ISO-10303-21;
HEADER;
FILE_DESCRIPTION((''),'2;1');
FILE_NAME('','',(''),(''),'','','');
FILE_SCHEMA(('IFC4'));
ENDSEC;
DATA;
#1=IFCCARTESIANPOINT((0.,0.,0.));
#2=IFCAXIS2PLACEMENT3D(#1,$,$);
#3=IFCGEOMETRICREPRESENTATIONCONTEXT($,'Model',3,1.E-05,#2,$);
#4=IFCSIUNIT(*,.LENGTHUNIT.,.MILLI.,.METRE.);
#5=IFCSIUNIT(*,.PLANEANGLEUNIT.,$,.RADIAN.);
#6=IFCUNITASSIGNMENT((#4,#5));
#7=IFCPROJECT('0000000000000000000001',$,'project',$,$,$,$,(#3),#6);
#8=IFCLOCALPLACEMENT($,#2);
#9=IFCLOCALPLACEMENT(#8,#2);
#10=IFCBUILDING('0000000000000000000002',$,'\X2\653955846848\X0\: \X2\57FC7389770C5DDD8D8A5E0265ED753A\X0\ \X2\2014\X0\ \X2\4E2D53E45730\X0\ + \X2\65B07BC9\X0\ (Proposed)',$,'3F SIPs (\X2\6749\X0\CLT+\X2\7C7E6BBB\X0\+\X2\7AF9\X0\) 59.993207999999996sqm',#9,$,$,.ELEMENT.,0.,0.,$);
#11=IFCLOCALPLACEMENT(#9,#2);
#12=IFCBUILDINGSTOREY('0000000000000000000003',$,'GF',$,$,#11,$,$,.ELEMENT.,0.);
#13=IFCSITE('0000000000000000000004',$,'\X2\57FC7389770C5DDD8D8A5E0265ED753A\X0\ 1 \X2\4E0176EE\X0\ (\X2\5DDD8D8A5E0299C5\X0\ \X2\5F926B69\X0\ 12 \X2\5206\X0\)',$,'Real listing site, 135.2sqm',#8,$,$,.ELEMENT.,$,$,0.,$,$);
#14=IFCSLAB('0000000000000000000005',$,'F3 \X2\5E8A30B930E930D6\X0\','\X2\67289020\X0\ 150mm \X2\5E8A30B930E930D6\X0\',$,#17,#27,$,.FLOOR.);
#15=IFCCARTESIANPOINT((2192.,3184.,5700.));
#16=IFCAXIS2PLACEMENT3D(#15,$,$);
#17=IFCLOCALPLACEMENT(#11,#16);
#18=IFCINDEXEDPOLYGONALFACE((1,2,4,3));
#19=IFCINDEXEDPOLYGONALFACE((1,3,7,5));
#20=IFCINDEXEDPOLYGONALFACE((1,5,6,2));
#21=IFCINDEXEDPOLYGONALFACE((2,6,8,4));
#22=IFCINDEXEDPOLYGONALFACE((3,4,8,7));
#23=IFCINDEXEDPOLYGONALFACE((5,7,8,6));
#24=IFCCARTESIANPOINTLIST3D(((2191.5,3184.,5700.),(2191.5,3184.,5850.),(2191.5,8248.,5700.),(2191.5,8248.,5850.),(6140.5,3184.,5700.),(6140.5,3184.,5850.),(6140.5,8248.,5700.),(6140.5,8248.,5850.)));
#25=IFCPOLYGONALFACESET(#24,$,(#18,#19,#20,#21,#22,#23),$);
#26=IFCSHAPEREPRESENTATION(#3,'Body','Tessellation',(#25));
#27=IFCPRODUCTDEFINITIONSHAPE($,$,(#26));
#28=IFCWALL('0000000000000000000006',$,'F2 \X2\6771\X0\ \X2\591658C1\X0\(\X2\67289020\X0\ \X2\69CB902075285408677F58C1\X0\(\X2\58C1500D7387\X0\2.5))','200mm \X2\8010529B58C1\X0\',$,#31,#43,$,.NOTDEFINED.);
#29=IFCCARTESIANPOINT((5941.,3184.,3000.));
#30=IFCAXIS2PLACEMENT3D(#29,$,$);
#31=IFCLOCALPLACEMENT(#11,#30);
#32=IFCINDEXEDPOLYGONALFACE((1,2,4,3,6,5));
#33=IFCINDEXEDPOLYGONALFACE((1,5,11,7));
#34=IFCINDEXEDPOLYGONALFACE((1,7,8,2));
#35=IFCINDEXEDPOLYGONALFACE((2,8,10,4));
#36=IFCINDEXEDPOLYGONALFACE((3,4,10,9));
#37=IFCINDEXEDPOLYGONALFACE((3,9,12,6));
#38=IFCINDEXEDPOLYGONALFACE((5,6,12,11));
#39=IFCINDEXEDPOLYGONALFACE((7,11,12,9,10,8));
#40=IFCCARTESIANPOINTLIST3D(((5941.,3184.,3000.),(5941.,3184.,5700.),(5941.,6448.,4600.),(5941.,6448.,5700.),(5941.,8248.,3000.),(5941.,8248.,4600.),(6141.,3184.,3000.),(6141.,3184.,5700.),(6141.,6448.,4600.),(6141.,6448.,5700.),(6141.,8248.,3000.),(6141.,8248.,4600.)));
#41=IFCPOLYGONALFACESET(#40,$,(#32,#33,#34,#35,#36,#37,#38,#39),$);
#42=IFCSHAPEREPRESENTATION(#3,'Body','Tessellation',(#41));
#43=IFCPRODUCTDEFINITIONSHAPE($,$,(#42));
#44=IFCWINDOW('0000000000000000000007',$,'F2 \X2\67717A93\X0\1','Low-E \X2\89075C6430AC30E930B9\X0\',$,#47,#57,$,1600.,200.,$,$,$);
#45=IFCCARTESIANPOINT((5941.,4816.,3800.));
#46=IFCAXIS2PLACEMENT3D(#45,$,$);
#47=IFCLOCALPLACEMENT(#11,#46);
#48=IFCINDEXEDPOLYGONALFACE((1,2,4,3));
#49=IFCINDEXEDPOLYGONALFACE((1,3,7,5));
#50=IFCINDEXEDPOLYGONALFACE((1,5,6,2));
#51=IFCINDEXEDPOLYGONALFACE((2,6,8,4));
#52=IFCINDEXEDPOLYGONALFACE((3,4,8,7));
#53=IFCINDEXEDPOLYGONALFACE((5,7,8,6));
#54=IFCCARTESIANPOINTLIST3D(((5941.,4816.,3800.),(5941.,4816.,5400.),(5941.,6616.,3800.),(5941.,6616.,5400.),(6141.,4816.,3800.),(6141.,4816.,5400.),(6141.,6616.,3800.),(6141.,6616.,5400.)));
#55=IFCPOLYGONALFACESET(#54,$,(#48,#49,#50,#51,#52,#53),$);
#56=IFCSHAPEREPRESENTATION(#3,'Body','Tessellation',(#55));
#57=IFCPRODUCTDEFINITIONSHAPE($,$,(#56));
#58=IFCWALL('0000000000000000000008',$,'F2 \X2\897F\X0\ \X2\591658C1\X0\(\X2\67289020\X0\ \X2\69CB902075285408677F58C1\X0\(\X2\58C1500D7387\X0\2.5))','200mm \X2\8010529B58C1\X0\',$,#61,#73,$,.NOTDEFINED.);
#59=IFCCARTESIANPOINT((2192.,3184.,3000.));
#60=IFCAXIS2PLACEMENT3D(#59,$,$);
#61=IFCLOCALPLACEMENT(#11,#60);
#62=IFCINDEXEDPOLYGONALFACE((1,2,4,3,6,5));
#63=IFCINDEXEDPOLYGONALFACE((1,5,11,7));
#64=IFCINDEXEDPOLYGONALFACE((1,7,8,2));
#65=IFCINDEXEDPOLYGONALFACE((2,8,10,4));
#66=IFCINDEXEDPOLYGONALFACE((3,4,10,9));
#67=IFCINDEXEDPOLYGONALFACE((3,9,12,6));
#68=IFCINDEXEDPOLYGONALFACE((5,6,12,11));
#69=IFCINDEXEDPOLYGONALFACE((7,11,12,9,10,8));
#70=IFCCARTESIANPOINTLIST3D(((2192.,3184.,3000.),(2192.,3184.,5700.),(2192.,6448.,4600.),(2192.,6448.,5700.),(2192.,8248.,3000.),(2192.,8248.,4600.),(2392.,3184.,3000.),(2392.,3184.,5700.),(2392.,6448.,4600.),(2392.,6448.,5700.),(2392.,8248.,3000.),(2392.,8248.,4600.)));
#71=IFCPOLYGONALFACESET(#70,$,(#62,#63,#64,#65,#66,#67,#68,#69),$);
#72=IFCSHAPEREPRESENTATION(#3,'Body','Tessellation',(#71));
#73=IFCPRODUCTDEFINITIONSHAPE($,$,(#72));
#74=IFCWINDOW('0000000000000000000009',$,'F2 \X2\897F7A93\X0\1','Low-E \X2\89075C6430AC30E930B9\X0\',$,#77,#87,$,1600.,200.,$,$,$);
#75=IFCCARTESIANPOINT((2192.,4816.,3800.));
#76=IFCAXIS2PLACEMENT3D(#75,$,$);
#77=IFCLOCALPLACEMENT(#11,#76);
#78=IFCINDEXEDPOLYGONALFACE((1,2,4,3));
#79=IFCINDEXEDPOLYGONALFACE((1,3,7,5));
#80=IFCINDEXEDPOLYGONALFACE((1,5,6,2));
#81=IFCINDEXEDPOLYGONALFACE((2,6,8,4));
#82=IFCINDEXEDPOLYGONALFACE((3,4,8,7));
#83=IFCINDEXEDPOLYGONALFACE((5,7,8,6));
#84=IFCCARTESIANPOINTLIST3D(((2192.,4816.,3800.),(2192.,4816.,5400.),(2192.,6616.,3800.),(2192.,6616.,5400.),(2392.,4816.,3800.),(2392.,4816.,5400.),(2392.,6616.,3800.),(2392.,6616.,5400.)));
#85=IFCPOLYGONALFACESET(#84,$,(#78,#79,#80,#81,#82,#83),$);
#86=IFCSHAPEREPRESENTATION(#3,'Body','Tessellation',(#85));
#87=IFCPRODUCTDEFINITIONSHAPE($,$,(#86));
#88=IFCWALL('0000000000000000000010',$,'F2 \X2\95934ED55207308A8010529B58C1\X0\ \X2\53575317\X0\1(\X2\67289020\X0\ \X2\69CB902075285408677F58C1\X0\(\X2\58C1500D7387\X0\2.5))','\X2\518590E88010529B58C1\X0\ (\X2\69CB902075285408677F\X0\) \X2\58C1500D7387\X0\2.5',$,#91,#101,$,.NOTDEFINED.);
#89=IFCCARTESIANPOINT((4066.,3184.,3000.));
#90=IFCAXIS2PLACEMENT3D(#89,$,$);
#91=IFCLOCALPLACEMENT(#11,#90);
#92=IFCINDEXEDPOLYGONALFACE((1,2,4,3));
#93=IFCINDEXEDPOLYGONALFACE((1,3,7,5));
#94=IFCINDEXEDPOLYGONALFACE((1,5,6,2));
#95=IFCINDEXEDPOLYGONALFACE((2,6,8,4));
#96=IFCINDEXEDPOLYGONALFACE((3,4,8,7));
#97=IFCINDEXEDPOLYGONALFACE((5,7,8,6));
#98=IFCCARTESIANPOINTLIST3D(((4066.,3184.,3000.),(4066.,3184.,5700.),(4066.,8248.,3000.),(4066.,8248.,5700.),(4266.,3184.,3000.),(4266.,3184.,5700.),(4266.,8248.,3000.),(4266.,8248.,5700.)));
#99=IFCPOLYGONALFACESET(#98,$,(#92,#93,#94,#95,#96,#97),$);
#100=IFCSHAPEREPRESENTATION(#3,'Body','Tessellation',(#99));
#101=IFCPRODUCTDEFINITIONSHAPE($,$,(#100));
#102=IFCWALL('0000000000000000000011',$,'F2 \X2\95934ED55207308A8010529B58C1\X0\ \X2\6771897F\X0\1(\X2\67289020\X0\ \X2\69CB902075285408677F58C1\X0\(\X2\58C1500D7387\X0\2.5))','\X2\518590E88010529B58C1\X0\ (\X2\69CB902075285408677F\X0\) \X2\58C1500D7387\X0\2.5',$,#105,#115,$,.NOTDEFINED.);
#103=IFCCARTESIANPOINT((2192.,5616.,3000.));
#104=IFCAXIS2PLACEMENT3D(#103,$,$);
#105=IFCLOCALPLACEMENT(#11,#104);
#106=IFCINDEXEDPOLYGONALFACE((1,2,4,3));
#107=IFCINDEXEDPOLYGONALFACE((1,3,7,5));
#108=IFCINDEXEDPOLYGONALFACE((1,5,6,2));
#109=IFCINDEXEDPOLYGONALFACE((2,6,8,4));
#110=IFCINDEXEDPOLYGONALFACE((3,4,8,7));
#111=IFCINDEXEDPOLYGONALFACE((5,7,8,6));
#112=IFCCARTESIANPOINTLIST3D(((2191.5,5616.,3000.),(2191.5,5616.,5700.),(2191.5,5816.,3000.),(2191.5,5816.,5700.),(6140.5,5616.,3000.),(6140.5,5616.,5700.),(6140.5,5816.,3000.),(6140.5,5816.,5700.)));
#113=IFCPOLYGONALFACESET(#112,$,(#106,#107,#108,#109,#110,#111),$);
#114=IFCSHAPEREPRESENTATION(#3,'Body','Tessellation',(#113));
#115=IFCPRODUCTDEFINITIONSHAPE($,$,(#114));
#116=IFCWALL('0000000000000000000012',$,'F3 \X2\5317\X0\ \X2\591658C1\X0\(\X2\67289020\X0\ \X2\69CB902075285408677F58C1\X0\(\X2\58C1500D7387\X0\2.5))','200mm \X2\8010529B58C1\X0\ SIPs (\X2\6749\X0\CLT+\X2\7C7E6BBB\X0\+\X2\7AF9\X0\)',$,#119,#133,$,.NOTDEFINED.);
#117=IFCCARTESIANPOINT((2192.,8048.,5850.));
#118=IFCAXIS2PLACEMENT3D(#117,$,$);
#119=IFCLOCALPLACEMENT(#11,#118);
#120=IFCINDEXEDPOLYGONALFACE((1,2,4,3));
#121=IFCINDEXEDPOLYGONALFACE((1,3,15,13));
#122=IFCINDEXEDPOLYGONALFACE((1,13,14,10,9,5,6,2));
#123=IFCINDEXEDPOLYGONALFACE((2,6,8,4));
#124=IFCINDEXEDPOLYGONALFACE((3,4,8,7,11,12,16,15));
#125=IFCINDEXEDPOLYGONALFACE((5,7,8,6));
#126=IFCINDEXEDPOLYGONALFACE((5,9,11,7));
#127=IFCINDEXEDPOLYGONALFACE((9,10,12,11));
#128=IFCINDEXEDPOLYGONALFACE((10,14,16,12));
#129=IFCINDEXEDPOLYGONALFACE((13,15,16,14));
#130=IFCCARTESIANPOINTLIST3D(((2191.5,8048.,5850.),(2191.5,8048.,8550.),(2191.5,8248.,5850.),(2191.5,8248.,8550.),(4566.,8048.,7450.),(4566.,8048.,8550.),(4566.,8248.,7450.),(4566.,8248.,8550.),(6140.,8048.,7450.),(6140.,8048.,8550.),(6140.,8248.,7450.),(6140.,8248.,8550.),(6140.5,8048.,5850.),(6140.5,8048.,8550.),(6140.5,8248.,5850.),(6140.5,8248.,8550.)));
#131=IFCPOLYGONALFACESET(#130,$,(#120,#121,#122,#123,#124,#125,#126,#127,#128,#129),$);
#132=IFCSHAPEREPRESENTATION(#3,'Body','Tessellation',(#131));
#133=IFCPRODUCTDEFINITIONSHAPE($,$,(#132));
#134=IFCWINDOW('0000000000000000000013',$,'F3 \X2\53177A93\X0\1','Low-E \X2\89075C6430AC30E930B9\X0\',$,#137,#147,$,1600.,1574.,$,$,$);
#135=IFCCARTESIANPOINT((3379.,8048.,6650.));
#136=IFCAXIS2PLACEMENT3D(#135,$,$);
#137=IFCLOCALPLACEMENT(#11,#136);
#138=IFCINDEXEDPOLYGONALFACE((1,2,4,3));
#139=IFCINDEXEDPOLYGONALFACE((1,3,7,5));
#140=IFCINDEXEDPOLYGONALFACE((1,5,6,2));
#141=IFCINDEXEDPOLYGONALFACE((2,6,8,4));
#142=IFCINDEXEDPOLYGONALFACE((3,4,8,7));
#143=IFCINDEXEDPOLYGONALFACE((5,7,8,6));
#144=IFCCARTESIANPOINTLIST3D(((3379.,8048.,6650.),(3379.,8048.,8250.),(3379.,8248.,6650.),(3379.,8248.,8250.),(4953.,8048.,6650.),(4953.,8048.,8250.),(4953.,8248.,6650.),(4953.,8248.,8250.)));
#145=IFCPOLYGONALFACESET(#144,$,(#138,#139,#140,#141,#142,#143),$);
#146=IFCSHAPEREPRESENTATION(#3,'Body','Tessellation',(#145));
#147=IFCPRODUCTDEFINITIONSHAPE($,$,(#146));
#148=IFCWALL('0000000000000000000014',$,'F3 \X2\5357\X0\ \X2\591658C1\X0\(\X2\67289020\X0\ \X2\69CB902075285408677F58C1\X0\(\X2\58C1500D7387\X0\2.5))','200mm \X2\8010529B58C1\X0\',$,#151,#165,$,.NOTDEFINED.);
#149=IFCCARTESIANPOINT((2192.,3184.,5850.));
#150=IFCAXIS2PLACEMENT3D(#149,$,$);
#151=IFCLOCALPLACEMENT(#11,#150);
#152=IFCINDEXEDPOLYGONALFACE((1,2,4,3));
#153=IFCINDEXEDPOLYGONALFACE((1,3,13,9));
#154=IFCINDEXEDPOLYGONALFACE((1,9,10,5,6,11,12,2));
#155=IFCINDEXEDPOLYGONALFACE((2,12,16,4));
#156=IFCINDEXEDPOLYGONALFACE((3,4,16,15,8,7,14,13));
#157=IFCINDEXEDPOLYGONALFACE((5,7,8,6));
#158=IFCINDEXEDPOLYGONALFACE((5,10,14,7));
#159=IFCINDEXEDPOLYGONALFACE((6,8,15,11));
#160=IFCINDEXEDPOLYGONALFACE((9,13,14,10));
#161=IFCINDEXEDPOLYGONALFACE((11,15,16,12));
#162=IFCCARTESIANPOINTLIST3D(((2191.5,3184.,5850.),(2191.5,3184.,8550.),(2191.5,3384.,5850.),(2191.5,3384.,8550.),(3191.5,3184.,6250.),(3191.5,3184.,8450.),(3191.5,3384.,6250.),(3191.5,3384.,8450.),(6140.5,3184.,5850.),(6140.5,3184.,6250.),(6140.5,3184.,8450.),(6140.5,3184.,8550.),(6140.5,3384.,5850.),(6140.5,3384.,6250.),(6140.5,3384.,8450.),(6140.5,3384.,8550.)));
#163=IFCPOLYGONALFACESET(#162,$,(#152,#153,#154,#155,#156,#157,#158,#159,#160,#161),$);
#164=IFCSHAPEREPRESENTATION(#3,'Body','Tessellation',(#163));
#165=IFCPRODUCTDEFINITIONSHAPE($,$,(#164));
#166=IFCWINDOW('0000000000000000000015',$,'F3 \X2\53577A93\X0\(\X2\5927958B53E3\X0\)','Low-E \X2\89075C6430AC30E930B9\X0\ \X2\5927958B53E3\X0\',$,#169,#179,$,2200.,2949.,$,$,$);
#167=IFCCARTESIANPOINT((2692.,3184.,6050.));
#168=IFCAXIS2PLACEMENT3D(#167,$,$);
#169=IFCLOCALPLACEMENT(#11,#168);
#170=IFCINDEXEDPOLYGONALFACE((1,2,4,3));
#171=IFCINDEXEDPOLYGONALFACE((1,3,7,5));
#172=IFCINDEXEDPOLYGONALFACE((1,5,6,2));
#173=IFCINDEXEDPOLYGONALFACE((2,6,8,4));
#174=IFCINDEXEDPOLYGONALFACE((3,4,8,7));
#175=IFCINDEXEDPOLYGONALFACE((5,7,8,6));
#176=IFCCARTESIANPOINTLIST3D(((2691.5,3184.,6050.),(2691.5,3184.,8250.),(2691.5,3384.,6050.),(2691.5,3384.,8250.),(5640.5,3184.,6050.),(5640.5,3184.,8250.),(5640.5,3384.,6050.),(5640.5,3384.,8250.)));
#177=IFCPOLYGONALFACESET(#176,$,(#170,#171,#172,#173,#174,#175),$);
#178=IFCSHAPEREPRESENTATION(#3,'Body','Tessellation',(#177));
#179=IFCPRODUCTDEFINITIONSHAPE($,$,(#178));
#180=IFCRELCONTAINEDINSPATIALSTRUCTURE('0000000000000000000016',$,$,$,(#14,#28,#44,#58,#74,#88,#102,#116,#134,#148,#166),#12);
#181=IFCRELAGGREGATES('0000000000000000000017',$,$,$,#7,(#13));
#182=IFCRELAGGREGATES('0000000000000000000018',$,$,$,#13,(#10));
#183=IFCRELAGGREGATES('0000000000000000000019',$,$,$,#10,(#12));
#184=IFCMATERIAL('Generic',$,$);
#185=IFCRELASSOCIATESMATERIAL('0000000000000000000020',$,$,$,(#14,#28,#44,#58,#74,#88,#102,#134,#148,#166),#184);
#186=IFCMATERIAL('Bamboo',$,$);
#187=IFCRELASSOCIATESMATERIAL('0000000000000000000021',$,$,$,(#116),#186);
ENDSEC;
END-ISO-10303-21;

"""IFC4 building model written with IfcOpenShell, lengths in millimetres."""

from ifc_helpers import new_model, si_unit, frame, frame_2d, origin, place, context, project, spatial, rectangle, extrude, material, element, fill, save


model = new_model("IFC4")

# Units and contexts
model_context = context("Model", 3, precision=1e-05, world=origin())
ifc_project = project(units=[si_unit("LENGTHUNIT", "METRE", prefix="MILLI"), si_unit("PLANEANGLEUNIT", "RADIAN")], contexts=[model_context])

# Site, building, storey
site_placement = place(None, origin())
site = spatial("IfcSite", under=ifc_project, at=site_placement, Name="埼玉県川越市旭町 1 丁目 (川越市駅 徒歩 12 分)", ObjectType="Real listing site, 135.2sqm", CompositionType="ELEMENT", RefElevation=0.0)
building_placement = place(site_placement, origin())
building = spatial("IfcBuilding", under=site, at=building_placement, Name="改善案: 埼玉県川越市旭町 — 中古地 + 新築 (Proposed)", ObjectType="3F SIPs (杉CLT+籾殻+竹) 59.993207999999996sqm", CompositionType="ELEMENT", ElevationOfRefHeight=0.0, ElevationOfTerrain=0.0)
storey_placement = place(building_placement, origin())
storey = spatial("IfcBuildingStorey", under=building, at=storey_placement, Name="GF", CompositionType="ELEMENT", Elevation=0.0)

# Slab
ifc_material_1 = material(Name="Generic")
slab_placement = place(storey_placement, frame((2192.0, 3184.0, 5700.0)))
element("IfcSlab", 1, at=slab_placement, inside=storey, material=ifc_material_1, Name="F3 床スラブ", Description="木造 150mm 床スラブ", PredefinedType="FLOOR", context=model_context, shape_type="SweptSolid", body=[
    extrude(rectangle(XDim=3949.0, YDim=5064.0, at=frame_2d((1974.0, 2532.0))), frame((2192.0, 3184.0, 5700.0)), (0.0, 0.0, 1.0), 150.0),
])

# Walls, openings, windows
wall_1_placement = place(storey_placement, frame((5941.0, 3184.0, 3000.0)))
wall_1 = element("IfcWall", 2, at=wall_1_placement, inside=storey, material=ifc_material_1, Name="F2 東 外壁(木造 構造用合板壁(壁倍率2.5))", Description="200mm 耐力壁", PredefinedType="NOTDEFINED", context=model_context, shape_type="SweptSolid", body=[
    extrude(rectangle(XDim=200.0, YDim=5064.0, at=frame_2d((100.0, 2532.0))), frame((5941.0, 3184.0, 3000.0)), (0.0, 0.0, 1.0), 2700.0),
])
opening_1_placement = place(storey_placement, frame((5941.0, 4816.0, 3800.0)))
opening_1 = element("IfcOpeningElement", 3, at=opening_1_placement, cuts=wall_1, PredefinedType="NOTDEFINED", context=model_context, shape_type="SweptSolid", body=[
    extrude(rectangle(XDim=200.0, YDim=1800.0, at=frame_2d((100.0, 900.0))), frame((5941.0, 4816.0, 3800.0)), (0.0, 0.0, 1.0), 1600.0),
])
window_1_placement = place(storey_placement, frame((5941.0, 4816.0, 3800.0)))
window_1 = element("IfcWindow", 4, at=window_1_placement, inside=storey, material=ifc_material_1, Name="F2 東窓1", Description="Low-E 複層ガラス", OverallHeight=1600.0, OverallWidth=200.0, context=model_context, shape_type="SweptSolid", body=[
    extrude(rectangle(XDim=200.0, YDim=1800.0, at=frame_2d((100.0, 900.0))), frame((5941.0, 4816.0, 3800.0)), (0.0, 0.0, 1.0), 1600.0),
])
fill(opening_1, window_1)
wall_2_placement = place(storey_placement, frame((2192.0, 3184.0, 3000.0)))
wall_2 = element("IfcWall", 5, at=wall_2_placement, inside=storey, material=ifc_material_1, Name="F2 西 外壁(木造 構造用合板壁(壁倍率2.5))", Description="200mm 耐力壁", PredefinedType="NOTDEFINED", context=model_context, shape_type="SweptSolid", body=[
    extrude(rectangle(XDim=200.0, YDim=5064.0, at=frame_2d((100.0, 2532.0))), frame((2192.0, 3184.0, 3000.0)), (0.0, 0.0, 1.0), 2700.0),
])
opening_2_placement = place(storey_placement, frame((2192.0, 4816.0, 3800.0)))
opening_2 = element("IfcOpeningElement", 6, at=opening_2_placement, cuts=wall_2, PredefinedType="NOTDEFINED", context=model_context, shape_type="SweptSolid", body=[
    extrude(rectangle(XDim=200.0, YDim=1800.0, at=frame_2d((100.0, 900.0))), frame((2192.0, 4816.0, 3800.0)), (0.0, 0.0, 1.0), 1600.0),
])
window_2_placement = place(storey_placement, frame((2192.0, 4816.0, 3800.0)))
window_2 = element("IfcWindow", 7, at=window_2_placement, inside=storey, material=ifc_material_1, Name="F2 西窓1", Description="Low-E 複層ガラス", OverallHeight=1600.0, OverallWidth=200.0, context=model_context, shape_type="SweptSolid", body=[
    extrude(rectangle(XDim=200.0, YDim=1800.0, at=frame_2d((100.0, 900.0))), frame((2192.0, 4816.0, 3800.0)), (0.0, 0.0, 1.0), 1600.0),
])
fill(opening_2, window_2)

# Walls
wall_3_placement = place(storey_placement, frame((4066.0, 3184.0, 3000.0)))
element("IfcWall", 8, at=wall_3_placement, inside=storey, material=ifc_material_1, Name="F2 間仕切り耐力壁 南北1(木造 構造用合板壁(壁倍率2.5))", Description="内部耐力壁 (構造用合板) 壁倍率2.5", PredefinedType="NOTDEFINED", context=model_context, shape_type="SweptSolid", body=[
    extrude(rectangle(XDim=200.0, YDim=5064.0, at=frame_2d((100.0, 2532.0))), frame((4066.0, 3184.0, 3000.0)), (0.0, 0.0, 1.0), 2700.0),
])
wall_4_placement = place(storey_placement, frame((2192.0, 5616.0, 3000.0)))
element("IfcWall", 9, at=wall_4_placement, inside=storey, material=ifc_material_1, Name="F2 間仕切り耐力壁 東西1(木造 構造用合板壁(壁倍率2.5))", Description="内部耐力壁 (構造用合板) 壁倍率2.5", PredefinedType="NOTDEFINED", context=model_context, shape_type="SweptSolid", body=[
    extrude(rectangle(XDim=3949.0, YDim=200.0, at=frame_2d((1974.0, 100.0))), frame((2192.0, 5616.0, 3000.0)), (0.0, 0.0, 1.0), 2700.0),
])

# Walls, openings, windows
ifc_material_2 = material(Name="Bamboo")
wall_5_placement = place(storey_placement, frame((2192.0, 8048.0, 5850.0)))
wall_5 = element("IfcWall", 10, at=wall_5_placement, inside=storey, material=ifc_material_2, Name="F3 北 外壁(木造 構造用合板壁(壁倍率2.5))", Description="200mm 耐力壁 SIPs (杉CLT+籾殻+竹)", PredefinedType="NOTDEFINED", context=model_context, shape_type="SweptSolid", body=[
    extrude(rectangle(XDim=3949.0, YDim=200.0, at=frame_2d((1974.0, 100.0))), frame((2192.0, 8048.0, 5850.0)), (0.0, 0.0, 1.0), 2700.0),
])
opening_3_placement = place(storey_placement, frame((3379.0, 8048.0, 6650.0)))
opening_3 = element("IfcOpeningElement", 11, at=opening_3_placement, cuts=wall_5, PredefinedType="NOTDEFINED", context=model_context, shape_type="SweptSolid", body=[
    extrude(rectangle(XDim=1574.0, YDim=200.0, at=frame_2d((787.0, 100.0))), frame((3379.0, 8048.0, 6650.0)), (0.0, 0.0, 1.0), 1600.0),
])
window_3_placement = place(storey_placement, frame((3379.0, 8048.0, 6650.0)))
window_3 = element("IfcWindow", 12, at=window_3_placement, inside=storey, material=ifc_material_1, Name="F3 北窓1", Description="Low-E 複層ガラス", OverallHeight=1600.0, OverallWidth=1574.0, context=model_context, shape_type="SweptSolid", body=[
    extrude(rectangle(XDim=1574.0, YDim=200.0, at=frame_2d((787.0, 100.0))), frame((3379.0, 8048.0, 6650.0)), (0.0, 0.0, 1.0), 1600.0),
])
fill(opening_3, window_3)
wall_6_placement = place(storey_placement, frame((2192.0, 3184.0, 5850.0)))
wall_6 = element("IfcWall", 13, at=wall_6_placement, inside=storey, material=ifc_material_1, Name="F3 南 外壁(木造 構造用合板壁(壁倍率2.5))", Description="200mm 耐力壁", PredefinedType="NOTDEFINED", context=model_context, shape_type="SweptSolid", body=[
    extrude(rectangle(XDim=3949.0, YDim=200.0, at=frame_2d((1974.0, 100.0))), frame((2192.0, 3184.0, 5850.0)), (0.0, 0.0, 1.0), 2700.0),
])
opening_4_placement = place(storey_placement, frame((2692.0, 3184.0, 6050.0)))
opening_4 = element("IfcOpeningElement", 14, at=opening_4_placement, cuts=wall_6, PredefinedType="NOTDEFINED", context=model_context, shape_type="SweptSolid", body=[
    extrude(rectangle(XDim=2949.0, YDim=200.0, at=frame_2d((1474.0, 100.0))), frame((2692.0, 3184.0, 6050.0)), (0.0, 0.0, 1.0), 2200.0),
])
window_4_placement = place(storey_placement, frame((2692.0, 3184.0, 6050.0)))
window_4 = element("IfcWindow", 15, at=window_4_placement, inside=storey, material=ifc_material_1, Name="F3 南窓(大開口)", Description="Low-E 複層ガラス 大開口", OverallHeight=2200.0, OverallWidth=2949.0, context=model_context, shape_type="SweptSolid", body=[
    extrude(rectangle(XDim=2949.0, YDim=200.0, at=frame_2d((1474.0, 100.0))), frame((2692.0, 3184.0, 6050.0)), (0.0, 0.0, 1.0), 2200.0),
])
fill(opening_4, window_4)

save(model, "model.ifc")
